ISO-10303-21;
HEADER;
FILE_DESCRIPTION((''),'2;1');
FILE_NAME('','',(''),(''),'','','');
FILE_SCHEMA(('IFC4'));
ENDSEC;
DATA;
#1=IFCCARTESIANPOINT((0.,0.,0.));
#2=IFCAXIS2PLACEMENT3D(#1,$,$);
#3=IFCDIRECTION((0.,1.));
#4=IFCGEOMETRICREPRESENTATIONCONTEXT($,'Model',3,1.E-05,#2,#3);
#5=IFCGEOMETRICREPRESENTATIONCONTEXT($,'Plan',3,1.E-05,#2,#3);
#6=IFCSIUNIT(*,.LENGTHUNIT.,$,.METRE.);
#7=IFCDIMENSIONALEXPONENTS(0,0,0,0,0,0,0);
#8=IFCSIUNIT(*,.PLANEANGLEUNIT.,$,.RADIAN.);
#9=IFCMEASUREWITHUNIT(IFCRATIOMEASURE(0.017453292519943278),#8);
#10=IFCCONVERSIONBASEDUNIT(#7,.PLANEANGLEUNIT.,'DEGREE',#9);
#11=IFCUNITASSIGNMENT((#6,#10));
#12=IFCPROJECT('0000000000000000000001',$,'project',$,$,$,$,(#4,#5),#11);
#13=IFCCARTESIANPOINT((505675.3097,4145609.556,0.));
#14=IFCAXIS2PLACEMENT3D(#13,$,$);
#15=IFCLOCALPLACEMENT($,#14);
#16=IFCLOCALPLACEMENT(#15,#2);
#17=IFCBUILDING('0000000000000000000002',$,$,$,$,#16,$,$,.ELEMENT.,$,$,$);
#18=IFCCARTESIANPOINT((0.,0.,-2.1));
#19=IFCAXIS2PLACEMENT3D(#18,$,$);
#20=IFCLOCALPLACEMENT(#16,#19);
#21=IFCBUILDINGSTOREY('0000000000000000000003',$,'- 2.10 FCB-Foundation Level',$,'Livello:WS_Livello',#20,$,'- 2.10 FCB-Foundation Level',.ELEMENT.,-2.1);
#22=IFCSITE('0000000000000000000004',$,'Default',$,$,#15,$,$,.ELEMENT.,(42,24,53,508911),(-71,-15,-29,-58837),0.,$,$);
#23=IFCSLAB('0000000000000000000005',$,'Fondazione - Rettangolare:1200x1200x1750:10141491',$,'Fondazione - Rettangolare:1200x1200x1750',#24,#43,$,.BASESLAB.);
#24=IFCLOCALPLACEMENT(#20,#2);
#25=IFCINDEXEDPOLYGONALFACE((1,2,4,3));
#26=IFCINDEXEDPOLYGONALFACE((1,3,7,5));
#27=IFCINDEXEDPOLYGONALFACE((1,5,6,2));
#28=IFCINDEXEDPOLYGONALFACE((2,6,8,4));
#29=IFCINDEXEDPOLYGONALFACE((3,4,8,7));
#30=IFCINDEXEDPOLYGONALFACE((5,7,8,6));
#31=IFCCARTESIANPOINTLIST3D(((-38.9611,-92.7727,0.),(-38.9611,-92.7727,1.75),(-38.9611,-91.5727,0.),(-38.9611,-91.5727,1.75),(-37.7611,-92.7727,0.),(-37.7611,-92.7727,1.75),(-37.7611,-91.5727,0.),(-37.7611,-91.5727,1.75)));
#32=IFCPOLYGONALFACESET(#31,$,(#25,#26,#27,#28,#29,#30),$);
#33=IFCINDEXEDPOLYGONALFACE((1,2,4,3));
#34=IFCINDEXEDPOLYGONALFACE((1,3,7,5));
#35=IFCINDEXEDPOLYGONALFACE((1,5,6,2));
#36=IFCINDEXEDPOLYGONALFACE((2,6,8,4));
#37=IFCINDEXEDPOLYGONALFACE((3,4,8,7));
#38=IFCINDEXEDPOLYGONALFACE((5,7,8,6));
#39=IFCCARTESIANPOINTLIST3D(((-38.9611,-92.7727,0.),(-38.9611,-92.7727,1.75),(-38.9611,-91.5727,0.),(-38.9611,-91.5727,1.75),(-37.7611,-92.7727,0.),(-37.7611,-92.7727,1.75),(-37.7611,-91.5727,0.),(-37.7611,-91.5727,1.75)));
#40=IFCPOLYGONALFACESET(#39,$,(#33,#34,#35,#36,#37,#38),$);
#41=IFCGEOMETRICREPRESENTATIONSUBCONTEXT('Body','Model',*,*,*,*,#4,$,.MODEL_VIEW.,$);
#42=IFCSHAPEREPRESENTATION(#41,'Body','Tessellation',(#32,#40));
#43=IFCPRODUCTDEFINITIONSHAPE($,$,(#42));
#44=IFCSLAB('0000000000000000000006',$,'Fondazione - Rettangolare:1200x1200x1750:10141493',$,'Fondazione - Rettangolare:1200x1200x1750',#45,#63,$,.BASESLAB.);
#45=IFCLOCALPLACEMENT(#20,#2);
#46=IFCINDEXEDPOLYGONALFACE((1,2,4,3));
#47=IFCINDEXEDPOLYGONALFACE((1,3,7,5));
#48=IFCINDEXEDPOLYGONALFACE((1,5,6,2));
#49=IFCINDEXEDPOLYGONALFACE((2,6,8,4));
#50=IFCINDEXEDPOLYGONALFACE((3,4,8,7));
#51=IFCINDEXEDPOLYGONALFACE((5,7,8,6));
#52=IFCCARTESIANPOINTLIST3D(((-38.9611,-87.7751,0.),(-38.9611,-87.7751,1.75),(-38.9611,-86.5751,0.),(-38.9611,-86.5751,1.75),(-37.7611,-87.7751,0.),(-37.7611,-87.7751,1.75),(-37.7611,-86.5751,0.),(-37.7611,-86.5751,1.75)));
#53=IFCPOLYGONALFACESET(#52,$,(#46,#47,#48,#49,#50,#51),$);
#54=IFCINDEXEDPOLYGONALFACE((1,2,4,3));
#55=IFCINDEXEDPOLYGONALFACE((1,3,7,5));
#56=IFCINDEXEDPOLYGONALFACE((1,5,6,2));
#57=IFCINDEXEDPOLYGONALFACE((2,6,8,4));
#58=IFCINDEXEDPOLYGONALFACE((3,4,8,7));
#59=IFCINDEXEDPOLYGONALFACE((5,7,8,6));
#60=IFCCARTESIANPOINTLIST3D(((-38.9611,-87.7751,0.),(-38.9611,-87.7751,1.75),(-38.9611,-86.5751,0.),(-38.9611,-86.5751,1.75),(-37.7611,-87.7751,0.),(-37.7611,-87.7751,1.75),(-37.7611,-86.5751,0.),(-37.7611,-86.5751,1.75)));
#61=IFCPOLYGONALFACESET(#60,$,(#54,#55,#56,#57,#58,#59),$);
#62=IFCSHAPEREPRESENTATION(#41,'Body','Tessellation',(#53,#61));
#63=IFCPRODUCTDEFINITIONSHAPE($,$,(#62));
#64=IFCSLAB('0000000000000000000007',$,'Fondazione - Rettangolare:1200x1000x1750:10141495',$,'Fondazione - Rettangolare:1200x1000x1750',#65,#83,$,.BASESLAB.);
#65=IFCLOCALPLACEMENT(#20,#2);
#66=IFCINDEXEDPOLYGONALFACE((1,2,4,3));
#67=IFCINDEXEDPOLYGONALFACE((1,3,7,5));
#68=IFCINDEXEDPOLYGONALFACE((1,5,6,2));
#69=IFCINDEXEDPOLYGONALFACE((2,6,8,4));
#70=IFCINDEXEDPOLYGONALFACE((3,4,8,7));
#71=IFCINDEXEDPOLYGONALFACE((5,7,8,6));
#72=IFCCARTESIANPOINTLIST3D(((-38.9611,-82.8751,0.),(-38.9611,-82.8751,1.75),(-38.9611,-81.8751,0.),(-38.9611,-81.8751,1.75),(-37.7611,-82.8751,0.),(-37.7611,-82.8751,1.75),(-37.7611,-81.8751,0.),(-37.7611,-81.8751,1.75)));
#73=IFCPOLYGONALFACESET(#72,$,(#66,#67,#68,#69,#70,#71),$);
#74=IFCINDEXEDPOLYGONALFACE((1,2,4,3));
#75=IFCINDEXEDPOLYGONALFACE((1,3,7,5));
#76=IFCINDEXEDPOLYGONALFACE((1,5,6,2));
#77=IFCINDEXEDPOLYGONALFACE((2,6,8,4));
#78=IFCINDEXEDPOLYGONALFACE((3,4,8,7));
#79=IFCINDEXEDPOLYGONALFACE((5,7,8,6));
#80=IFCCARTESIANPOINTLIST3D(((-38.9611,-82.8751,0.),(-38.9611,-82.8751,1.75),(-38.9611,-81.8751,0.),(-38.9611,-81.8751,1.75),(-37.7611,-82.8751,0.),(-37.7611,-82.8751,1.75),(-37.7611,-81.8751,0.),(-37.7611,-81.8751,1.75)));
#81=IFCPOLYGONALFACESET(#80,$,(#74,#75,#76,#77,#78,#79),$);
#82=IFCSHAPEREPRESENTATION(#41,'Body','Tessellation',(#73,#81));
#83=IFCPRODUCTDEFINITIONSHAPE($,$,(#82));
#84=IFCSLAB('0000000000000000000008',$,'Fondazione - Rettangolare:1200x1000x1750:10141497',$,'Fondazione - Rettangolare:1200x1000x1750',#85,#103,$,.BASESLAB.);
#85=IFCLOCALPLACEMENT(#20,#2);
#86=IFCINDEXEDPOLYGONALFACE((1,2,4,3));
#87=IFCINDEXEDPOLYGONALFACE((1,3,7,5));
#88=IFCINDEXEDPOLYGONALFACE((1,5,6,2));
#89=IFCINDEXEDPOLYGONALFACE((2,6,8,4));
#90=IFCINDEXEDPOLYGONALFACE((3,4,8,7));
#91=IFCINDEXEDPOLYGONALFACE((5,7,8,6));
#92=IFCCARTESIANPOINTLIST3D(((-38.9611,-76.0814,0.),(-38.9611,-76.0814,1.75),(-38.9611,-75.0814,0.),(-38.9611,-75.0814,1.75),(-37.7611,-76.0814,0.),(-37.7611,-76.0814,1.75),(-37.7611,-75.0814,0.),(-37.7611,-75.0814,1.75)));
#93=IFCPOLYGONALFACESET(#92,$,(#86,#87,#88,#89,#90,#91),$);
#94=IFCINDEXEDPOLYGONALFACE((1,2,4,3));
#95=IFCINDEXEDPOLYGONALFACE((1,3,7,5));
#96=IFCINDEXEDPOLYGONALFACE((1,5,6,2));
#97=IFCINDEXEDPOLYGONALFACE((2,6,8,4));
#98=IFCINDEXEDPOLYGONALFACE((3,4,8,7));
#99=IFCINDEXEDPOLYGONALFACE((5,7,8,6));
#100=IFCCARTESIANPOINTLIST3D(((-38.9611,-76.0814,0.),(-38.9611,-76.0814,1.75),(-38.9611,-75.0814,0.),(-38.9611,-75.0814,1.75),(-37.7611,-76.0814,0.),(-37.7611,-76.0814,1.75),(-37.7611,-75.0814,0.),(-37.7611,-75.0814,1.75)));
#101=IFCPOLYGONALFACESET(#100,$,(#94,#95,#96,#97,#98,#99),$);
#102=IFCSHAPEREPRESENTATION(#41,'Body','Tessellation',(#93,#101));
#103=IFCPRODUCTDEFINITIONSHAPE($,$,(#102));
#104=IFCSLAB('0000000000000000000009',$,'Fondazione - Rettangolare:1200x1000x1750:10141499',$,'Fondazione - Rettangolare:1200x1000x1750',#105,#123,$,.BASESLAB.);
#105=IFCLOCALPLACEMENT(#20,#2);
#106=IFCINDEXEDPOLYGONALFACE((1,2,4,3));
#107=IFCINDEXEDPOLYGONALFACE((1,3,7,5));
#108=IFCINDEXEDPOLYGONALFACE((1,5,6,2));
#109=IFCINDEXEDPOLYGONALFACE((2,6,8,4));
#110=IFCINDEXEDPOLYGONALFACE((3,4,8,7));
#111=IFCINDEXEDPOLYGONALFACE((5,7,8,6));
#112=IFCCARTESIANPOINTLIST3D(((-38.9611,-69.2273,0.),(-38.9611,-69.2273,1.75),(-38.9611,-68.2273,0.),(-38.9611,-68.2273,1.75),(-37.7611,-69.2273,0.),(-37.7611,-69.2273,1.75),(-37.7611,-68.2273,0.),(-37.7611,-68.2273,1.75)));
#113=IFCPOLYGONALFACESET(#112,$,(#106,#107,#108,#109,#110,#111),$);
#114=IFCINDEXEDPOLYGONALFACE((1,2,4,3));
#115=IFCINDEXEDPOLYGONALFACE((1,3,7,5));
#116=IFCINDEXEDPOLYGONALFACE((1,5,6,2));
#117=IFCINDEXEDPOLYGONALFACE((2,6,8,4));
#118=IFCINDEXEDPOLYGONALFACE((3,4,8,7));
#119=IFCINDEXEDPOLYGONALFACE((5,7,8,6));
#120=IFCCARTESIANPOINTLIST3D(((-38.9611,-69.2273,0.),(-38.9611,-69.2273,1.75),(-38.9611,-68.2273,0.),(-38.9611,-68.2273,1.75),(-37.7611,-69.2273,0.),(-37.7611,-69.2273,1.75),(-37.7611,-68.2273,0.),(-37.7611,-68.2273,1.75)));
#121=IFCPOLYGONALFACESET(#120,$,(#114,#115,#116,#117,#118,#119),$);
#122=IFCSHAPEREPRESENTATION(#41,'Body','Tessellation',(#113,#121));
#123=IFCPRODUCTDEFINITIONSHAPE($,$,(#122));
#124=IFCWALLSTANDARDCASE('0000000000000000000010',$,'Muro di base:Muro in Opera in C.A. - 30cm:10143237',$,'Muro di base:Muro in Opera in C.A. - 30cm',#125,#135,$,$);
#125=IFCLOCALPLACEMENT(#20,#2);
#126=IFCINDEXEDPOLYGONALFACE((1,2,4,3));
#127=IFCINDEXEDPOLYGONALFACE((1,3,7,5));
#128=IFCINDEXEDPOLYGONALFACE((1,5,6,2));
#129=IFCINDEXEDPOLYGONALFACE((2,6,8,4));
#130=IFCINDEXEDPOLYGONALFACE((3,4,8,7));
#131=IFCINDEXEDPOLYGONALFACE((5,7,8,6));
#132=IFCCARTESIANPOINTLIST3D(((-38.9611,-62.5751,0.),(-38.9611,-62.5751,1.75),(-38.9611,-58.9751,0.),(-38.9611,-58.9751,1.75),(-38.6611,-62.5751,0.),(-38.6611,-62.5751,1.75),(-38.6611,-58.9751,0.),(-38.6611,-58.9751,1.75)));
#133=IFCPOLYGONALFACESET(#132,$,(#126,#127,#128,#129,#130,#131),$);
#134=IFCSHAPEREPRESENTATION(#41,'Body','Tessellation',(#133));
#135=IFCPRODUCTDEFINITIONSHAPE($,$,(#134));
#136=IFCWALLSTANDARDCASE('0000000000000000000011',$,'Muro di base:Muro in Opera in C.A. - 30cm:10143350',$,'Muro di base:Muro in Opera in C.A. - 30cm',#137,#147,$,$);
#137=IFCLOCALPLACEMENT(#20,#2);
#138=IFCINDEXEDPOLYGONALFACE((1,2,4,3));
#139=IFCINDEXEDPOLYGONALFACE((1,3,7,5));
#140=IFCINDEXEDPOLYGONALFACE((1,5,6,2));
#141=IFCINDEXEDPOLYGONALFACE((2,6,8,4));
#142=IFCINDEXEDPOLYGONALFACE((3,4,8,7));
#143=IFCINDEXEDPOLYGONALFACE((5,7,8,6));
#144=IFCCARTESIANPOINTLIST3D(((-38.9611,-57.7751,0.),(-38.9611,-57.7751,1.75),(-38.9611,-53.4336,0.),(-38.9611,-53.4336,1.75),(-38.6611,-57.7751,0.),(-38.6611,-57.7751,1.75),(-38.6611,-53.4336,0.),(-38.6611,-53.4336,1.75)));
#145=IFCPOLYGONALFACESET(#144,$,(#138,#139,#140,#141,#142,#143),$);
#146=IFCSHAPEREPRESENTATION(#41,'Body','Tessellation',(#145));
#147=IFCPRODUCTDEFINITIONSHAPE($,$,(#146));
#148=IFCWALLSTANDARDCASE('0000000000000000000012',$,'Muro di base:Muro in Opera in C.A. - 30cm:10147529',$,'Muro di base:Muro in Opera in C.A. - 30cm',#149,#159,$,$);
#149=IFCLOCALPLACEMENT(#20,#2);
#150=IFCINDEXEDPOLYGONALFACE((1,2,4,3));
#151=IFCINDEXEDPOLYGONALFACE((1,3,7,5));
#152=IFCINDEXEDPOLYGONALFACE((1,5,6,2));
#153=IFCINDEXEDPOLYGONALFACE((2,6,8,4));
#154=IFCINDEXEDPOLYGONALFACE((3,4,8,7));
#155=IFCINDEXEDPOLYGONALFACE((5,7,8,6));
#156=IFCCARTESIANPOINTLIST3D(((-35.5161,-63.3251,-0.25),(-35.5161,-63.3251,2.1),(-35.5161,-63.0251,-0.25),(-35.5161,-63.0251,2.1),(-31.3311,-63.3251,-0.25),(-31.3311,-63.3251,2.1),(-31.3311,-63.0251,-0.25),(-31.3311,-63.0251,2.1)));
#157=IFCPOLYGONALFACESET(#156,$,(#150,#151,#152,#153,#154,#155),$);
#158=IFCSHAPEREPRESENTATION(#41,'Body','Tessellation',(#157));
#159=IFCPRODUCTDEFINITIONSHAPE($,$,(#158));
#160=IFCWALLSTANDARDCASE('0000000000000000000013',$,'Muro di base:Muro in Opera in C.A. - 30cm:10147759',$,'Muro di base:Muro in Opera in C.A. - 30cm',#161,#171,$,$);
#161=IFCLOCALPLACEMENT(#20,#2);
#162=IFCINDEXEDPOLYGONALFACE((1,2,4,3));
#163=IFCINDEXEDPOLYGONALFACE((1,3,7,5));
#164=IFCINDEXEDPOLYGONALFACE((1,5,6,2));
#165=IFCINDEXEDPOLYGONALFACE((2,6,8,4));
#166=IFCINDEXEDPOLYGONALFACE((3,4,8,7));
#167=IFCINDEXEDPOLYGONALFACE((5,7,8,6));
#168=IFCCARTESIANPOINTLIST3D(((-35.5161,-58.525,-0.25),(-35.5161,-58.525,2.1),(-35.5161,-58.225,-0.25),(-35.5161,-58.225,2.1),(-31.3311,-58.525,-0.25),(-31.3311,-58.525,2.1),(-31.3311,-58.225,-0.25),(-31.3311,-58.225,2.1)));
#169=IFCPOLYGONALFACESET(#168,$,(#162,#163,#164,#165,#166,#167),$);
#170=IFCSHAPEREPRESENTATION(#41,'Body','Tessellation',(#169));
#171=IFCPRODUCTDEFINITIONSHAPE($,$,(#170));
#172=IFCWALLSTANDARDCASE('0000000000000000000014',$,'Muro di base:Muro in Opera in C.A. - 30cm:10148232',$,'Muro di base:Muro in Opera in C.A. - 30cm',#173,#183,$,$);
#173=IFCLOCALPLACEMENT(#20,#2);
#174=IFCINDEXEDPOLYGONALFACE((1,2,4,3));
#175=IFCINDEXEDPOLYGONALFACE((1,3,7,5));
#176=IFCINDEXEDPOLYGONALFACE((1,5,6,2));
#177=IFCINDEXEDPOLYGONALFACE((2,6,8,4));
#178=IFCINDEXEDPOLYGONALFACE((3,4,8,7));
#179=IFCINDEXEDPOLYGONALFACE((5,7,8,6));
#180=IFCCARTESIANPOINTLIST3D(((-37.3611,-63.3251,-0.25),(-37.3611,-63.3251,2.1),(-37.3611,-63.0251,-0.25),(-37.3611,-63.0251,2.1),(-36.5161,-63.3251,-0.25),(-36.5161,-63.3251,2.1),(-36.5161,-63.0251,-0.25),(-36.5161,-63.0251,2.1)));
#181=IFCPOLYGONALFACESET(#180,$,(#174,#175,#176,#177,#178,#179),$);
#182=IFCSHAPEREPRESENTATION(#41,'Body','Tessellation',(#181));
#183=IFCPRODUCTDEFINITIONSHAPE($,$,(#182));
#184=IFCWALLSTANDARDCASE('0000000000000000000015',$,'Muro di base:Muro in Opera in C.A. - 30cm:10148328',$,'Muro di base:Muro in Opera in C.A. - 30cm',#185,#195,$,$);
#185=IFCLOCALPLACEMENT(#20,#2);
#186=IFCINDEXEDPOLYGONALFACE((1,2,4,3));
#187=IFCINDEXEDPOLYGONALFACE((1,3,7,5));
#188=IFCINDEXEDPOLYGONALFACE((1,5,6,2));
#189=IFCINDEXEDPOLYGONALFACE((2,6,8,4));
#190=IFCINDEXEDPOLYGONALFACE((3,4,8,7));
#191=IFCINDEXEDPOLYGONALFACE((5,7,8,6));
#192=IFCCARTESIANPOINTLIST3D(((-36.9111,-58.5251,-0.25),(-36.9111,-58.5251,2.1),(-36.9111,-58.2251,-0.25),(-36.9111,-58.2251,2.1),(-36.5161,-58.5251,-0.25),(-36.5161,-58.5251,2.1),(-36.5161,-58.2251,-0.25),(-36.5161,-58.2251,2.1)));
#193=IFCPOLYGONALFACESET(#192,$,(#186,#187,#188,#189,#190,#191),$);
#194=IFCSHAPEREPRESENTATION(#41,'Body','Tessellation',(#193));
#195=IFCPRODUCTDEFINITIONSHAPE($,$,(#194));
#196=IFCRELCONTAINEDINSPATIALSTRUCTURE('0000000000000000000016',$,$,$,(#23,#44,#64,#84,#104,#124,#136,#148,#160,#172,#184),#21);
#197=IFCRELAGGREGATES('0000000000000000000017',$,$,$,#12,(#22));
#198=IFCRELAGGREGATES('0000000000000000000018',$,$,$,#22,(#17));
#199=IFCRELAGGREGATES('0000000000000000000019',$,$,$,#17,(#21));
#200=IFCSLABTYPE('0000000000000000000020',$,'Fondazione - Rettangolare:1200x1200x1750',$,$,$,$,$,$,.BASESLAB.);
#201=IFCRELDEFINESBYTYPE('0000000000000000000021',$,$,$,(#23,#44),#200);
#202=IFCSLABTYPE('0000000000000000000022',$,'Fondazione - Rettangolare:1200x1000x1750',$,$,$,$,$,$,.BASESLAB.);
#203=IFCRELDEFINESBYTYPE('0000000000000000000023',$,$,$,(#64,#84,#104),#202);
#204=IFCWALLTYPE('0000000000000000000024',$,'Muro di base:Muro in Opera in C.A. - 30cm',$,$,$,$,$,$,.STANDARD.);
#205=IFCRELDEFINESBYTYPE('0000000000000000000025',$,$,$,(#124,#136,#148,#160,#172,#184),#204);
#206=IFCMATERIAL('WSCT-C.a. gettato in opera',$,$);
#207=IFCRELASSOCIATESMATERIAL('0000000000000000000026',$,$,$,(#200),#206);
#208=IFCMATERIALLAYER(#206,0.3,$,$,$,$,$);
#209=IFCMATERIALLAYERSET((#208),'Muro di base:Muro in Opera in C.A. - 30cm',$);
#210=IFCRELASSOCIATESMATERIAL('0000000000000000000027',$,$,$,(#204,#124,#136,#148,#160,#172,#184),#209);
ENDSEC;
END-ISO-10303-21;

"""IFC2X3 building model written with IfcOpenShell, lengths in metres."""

from ifc_helpers import new_model, entity, si_unit, converted_unit, direction, frame, frame_2d, origin, place, context, subcontext, project, spatial, rectangle, extrude, material, layer, layer_set, layer_usage, type_object, element, save


model = new_model("IFC2X3")

# Units and contexts
model_context = context("Model", 3, precision=1e-05, world=origin(), true_north=direction((0.0, 1.0)))
plan_context = context("Plan", 3, precision=1e-05, world=origin(), true_north=direction((0.0, 1.0)))
body_context = subcontext(model_context, "Body", "Model", "MODEL_VIEW")
ifc_project = project(units=[si_unit("LENGTHUNIT", "METRE"), converted_unit("PLANEANGLEUNIT", "DEGREE", entity("IfcRatioMeasure", 0.017453292519943278), si_unit("PLANEANGLEUNIT", "RADIAN"), dimensions=[0, 0, 0, 0, 0, 0, 0])], contexts=[model_context, plan_context])

# Site, building, storey
site_placement = place(None, frame((505675.3097, 4145609.556, 0.0)))
site = spatial("IfcSite", under=ifc_project, at=site_placement, Name="Default", CompositionType="ELEMENT", RefLatitude=(42, 24, 53, 508911), RefLongitude=(-71, -15, -29, -58837), RefElevation=0.0)
building_placement = place(site_placement, origin())
building = spatial("IfcBuilding", under=site, at=building_placement, CompositionType="ELEMENT")
storey_placement = place(building_placement, frame((0.0, 0.0, -2.1)))
storey = spatial("IfcBuildingStorey", under=building, at=storey_placement, Name="- 2.10 FCB-Foundation Level", ObjectType="Livello:WS_Livello", LongName="- 2.10 FCB-Foundation Level", CompositionType="ELEMENT", Elevation=-2.1)

# Slabs
ifc_material = material(Name="WSCT-C.a. gettato in opera")
slab_type_1 = type_object("IfcSlabType", Name="Fondazione - Rettangolare:1200x1200x1750", PredefinedType="BASESLAB", material=ifc_material)
slab_1_placement = place(storey_placement, origin())
element("IfcSlab", 1, at=slab_1_placement, inside=storey, type_object=slab_type_1, Name="Fondazione - Rettangolare:1200x1200x1750:10141491", ObjectType="Fondazione - Rettangolare:1200x1200x1750", PredefinedType="BASESLAB", context=body_context, shape_type="SweptSolid", body=[
    extrude(rectangle(XDim=1.2, YDim=1.2, at=frame_2d((0.0, 0.0), x_axis=(1.0, 0.0))), frame((-38.3611, -92.1727, 0.0), z_axis=(0.0, 0.0, 1.0), x_axis=(-1.0, 0.0, 0.0)), (0.0, 0.0, 1.0), 1.75),
    extrude(rectangle(XDim=1.2, YDim=1.2, at=frame_2d((0.0, 0.0), x_axis=(1.0, 0.0))), frame((-38.3611, -92.1727, 0.0), z_axis=(0.0, 0.0, 1.0), x_axis=(-1.0, 0.0, 0.0)), (0.0, 0.0, 1.0), 1.75),
])
slab_2_placement = place(storey_placement, origin())
element("IfcSlab", 2, at=slab_2_placement, inside=storey, type_object=slab_type_1, Name="Fondazione - Rettangolare:1200x1200x1750:10141493", ObjectType="Fondazione - Rettangolare:1200x1200x1750", PredefinedType="BASESLAB", context=body_context, shape_type="SweptSolid", body=[
    extrude(rectangle(XDim=1.2, YDim=1.2, at=frame_2d((0.0, 0.0), x_axis=(1.0, 0.0))), frame((-38.3611, -87.1751, 0.0), z_axis=(0.0, 0.0, 1.0), x_axis=(-1.0, 0.0, 0.0)), (0.0, 0.0, 1.0), 1.75),
    extrude(rectangle(XDim=1.2, YDim=1.2, at=frame_2d((0.0, 0.0), x_axis=(1.0, 0.0))), frame((-38.3611, -87.1751, 0.0), z_axis=(0.0, 0.0, 1.0), x_axis=(-1.0, 0.0, 0.0)), (0.0, 0.0, 1.0), 1.75),
])
slab_type_2 = type_object("IfcSlabType", Name="Fondazione - Rettangolare:1200x1000x1750", PredefinedType="BASESLAB")
slab_3_placement = place(storey_placement, origin())
element("IfcSlab", 3, at=slab_3_placement, inside=storey, type_object=slab_type_2, Name="Fondazione - Rettangolare:1200x1000x1750:10141495", ObjectType="Fondazione - Rettangolare:1200x1000x1750", PredefinedType="BASESLAB", context=body_context, shape_type="SweptSolid", body=[
    extrude(rectangle(XDim=1.2, YDim=1.0, at=frame_2d((0.0, 0.0), x_axis=(1.0, 0.0))), frame((-38.3611, -82.3751, 0.0), z_axis=(0.0, 0.0, 1.0), x_axis=(-1.0, 0.0, 0.0)), (0.0, 0.0, 1.0), 1.75),
    extrude(rectangle(XDim=1.2, YDim=1.0, at=frame_2d((0.0, 0.0), x_axis=(1.0, 0.0))), frame((-38.3611, -82.3751, 0.0), z_axis=(0.0, 0.0, 1.0), x_axis=(-1.0, 0.0, 0.0)), (0.0, 0.0, 1.0), 1.75),
])
slab_4_placement = place(storey_placement, origin())
element("IfcSlab", 4, at=slab_4_placement, inside=storey, type_object=slab_type_2, Name="Fondazione - Rettangolare:1200x1000x1750:10141497", ObjectType="Fondazione - Rettangolare:1200x1000x1750", PredefinedType="BASESLAB", context=body_context, shape_type="SweptSolid", body=[
    extrude(rectangle(XDim=1.2, YDim=1.0, at=frame_2d((0.0, 0.0), x_axis=(1.0, 0.0))), frame((-38.3611, -75.5814, 0.0), z_axis=(0.0, 0.0, 1.0), x_axis=(-1.0, 0.0, 0.0)), (0.0, 0.0, 1.0), 1.75),
    extrude(rectangle(XDim=1.2, YDim=1.0, at=frame_2d((0.0, 0.0), x_axis=(1.0, 0.0))), frame((-38.3611, -75.5814, 0.0), z_axis=(0.0, 0.0, 1.0), x_axis=(-1.0, 0.0, 0.0)), (0.0, 0.0, 1.0), 1.75),
])
slab_5_placement = place(storey_placement, origin())
element("IfcSlab", 5, at=slab_5_placement, inside=storey, type_object=slab_type_2, Name="Fondazione - Rettangolare:1200x1000x1750:10141499", ObjectType="Fondazione - Rettangolare:1200x1000x1750", PredefinedType="BASESLAB", context=body_context, shape_type="SweptSolid", body=[
    extrude(rectangle(XDim=1.2, YDim=1.0, at=frame_2d((0.0, 0.0), x_axis=(1.0, 0.0))), frame((-38.3611, -68.7273, 0.0), z_axis=(0.0, 0.0, 1.0), x_axis=(-1.0, 0.0, 0.0)), (0.0, 0.0, 1.0), 1.75),
    extrude(rectangle(XDim=1.2, YDim=1.0, at=frame_2d((0.0, 0.0), x_axis=(1.0, 0.0))), frame((-38.3611, -68.7273, 0.0), z_axis=(0.0, 0.0, 1.0), x_axis=(-1.0, 0.0, 0.0)), (0.0, 0.0, 1.0), 1.75),
])

# Walls
ifc_layer_1 = layer(ifc_material, 0.3)
ifc_layer_set_1 = layer_set([ifc_layer_1], Name="Muro di base:Muro in Opera in C.A. - 30cm")
ifc_layer_usage_1 = layer_usage(ifc_layer_set_1, "AXIS2", "NEGATIVE", 0.15)
wall_type_1 = type_object("IfcWallType", Name="Muro di base:Muro in Opera in C.A. - 30cm", PredefinedType="STANDARD", material=ifc_layer_set_1)
wall_1_placement = place(storey_placement, frame((-38.8111, -62.5751, 0.0), z_axis=(0.0, 0.0, 1.0), x_axis=(0.0, 1.0, 0.0)))
element("IfcWallStandardCase", 6, at=wall_1_placement, inside=storey, type_object=wall_type_1, material=ifc_layer_usage_1, Name="Muro di base:Muro in Opera in C.A. - 30cm:10143237", ObjectType="Muro di base:Muro in Opera in C.A. - 30cm", context=body_context, shape_type="SweptSolid", body=[
    extrude(rectangle(XDim=3.6, YDim=0.3, at=frame_2d((1.8, 0.0), x_axis=(-1.0, 0.0))), origin(), (0.0, 0.0, 1.0), 1.75),
])
wall_2_placement = place(storey_placement, frame((-38.8111, -57.7751, 0.0), z_axis=(0.0, 0.0, 1.0), x_axis=(0.0, 1.0, 0.0)))
element("IfcWallStandardCase", 7, at=wall_2_placement, inside=storey, type_object=wall_type_1, material=ifc_layer_usage_1, Name="Muro di base:Muro in Opera in C.A. - 30cm:10143350", ObjectType="Muro di base:Muro in Opera in C.A. - 30cm", context=body_context, shape_type="SweptSolid", body=[
    extrude(rectangle(XDim=4.3415, YDim=0.3, at=frame_2d((2.1707, 0.0), x_axis=(-1.0, 0.0))), origin(), (0.0, 0.0, 1.0), 1.75),
])
for number, where, name in (
    (8, (-35.5161, -63.1751, -0.25), "Muro di base:Muro in Opera in C.A. - 30cm:10147529"),
    (9, (-35.5161, -58.375, -0.25), "Muro di base:Muro in Opera in C.A. - 30cm:10147759"),
):
    element("IfcWallStandardCase", number, at=place(storey_placement, frame(where)), inside=storey, type_object=wall_type_1, material=ifc_layer_usage_1, Name=name, ObjectType="Muro di base:Muro in Opera in C.A. - 30cm", context=body_context, shape_type="SweptSolid", body=[
        extrude(rectangle(XDim=4.1851, YDim=0.3, at=frame_2d((2.0925, 0.0), x_axis=(-1.0, 0.0))), origin(), (0.0, 0.0, 1.0), 2.35),
    ])
wall_3_placement = place(storey_placement, frame((-36.5161, -63.1751, -0.25), z_axis=(0.0, 0.0, 1.0), x_axis=(-1.0, 0.0, 0.0)))
element("IfcWallStandardCase", 10, at=wall_3_placement, inside=storey, type_object=wall_type_1, material=ifc_layer_usage_1, Name="Muro di base:Muro in Opera in C.A. - 30cm:10148232", ObjectType="Muro di base:Muro in Opera in C.A. - 30cm", context=body_context, shape_type="SweptSolid", body=[
    extrude(rectangle(XDim=0.8449, YDim=0.3, at=frame_2d((0.4225, 0.0), x_axis=(-1.0, 0.0))), origin(), (0.0, 0.0, 1.0), 2.35),
])
wall_4_placement = place(storey_placement, frame((-36.5161, -58.3751, -0.25), z_axis=(0.0, 0.0, 1.0), x_axis=(-1.0, 0.0, 0.0)))
element("IfcWallStandardCase", 11, at=wall_4_placement, inside=storey, type_object=wall_type_1, material=ifc_layer_usage_1, Name="Muro di base:Muro in Opera in C.A. - 30cm:10148328", ObjectType="Muro di base:Muro in Opera in C.A. - 30cm", context=body_context, shape_type="SweptSolid", body=[
    extrude(rectangle(XDim=0.3949, YDim=0.3, at=frame_2d((0.1975, 0.0), x_axis=(-1.0, 0.0))), origin(), (0.0, 0.0, 1.0), 2.35),
])

save(model, "model.ifc")
